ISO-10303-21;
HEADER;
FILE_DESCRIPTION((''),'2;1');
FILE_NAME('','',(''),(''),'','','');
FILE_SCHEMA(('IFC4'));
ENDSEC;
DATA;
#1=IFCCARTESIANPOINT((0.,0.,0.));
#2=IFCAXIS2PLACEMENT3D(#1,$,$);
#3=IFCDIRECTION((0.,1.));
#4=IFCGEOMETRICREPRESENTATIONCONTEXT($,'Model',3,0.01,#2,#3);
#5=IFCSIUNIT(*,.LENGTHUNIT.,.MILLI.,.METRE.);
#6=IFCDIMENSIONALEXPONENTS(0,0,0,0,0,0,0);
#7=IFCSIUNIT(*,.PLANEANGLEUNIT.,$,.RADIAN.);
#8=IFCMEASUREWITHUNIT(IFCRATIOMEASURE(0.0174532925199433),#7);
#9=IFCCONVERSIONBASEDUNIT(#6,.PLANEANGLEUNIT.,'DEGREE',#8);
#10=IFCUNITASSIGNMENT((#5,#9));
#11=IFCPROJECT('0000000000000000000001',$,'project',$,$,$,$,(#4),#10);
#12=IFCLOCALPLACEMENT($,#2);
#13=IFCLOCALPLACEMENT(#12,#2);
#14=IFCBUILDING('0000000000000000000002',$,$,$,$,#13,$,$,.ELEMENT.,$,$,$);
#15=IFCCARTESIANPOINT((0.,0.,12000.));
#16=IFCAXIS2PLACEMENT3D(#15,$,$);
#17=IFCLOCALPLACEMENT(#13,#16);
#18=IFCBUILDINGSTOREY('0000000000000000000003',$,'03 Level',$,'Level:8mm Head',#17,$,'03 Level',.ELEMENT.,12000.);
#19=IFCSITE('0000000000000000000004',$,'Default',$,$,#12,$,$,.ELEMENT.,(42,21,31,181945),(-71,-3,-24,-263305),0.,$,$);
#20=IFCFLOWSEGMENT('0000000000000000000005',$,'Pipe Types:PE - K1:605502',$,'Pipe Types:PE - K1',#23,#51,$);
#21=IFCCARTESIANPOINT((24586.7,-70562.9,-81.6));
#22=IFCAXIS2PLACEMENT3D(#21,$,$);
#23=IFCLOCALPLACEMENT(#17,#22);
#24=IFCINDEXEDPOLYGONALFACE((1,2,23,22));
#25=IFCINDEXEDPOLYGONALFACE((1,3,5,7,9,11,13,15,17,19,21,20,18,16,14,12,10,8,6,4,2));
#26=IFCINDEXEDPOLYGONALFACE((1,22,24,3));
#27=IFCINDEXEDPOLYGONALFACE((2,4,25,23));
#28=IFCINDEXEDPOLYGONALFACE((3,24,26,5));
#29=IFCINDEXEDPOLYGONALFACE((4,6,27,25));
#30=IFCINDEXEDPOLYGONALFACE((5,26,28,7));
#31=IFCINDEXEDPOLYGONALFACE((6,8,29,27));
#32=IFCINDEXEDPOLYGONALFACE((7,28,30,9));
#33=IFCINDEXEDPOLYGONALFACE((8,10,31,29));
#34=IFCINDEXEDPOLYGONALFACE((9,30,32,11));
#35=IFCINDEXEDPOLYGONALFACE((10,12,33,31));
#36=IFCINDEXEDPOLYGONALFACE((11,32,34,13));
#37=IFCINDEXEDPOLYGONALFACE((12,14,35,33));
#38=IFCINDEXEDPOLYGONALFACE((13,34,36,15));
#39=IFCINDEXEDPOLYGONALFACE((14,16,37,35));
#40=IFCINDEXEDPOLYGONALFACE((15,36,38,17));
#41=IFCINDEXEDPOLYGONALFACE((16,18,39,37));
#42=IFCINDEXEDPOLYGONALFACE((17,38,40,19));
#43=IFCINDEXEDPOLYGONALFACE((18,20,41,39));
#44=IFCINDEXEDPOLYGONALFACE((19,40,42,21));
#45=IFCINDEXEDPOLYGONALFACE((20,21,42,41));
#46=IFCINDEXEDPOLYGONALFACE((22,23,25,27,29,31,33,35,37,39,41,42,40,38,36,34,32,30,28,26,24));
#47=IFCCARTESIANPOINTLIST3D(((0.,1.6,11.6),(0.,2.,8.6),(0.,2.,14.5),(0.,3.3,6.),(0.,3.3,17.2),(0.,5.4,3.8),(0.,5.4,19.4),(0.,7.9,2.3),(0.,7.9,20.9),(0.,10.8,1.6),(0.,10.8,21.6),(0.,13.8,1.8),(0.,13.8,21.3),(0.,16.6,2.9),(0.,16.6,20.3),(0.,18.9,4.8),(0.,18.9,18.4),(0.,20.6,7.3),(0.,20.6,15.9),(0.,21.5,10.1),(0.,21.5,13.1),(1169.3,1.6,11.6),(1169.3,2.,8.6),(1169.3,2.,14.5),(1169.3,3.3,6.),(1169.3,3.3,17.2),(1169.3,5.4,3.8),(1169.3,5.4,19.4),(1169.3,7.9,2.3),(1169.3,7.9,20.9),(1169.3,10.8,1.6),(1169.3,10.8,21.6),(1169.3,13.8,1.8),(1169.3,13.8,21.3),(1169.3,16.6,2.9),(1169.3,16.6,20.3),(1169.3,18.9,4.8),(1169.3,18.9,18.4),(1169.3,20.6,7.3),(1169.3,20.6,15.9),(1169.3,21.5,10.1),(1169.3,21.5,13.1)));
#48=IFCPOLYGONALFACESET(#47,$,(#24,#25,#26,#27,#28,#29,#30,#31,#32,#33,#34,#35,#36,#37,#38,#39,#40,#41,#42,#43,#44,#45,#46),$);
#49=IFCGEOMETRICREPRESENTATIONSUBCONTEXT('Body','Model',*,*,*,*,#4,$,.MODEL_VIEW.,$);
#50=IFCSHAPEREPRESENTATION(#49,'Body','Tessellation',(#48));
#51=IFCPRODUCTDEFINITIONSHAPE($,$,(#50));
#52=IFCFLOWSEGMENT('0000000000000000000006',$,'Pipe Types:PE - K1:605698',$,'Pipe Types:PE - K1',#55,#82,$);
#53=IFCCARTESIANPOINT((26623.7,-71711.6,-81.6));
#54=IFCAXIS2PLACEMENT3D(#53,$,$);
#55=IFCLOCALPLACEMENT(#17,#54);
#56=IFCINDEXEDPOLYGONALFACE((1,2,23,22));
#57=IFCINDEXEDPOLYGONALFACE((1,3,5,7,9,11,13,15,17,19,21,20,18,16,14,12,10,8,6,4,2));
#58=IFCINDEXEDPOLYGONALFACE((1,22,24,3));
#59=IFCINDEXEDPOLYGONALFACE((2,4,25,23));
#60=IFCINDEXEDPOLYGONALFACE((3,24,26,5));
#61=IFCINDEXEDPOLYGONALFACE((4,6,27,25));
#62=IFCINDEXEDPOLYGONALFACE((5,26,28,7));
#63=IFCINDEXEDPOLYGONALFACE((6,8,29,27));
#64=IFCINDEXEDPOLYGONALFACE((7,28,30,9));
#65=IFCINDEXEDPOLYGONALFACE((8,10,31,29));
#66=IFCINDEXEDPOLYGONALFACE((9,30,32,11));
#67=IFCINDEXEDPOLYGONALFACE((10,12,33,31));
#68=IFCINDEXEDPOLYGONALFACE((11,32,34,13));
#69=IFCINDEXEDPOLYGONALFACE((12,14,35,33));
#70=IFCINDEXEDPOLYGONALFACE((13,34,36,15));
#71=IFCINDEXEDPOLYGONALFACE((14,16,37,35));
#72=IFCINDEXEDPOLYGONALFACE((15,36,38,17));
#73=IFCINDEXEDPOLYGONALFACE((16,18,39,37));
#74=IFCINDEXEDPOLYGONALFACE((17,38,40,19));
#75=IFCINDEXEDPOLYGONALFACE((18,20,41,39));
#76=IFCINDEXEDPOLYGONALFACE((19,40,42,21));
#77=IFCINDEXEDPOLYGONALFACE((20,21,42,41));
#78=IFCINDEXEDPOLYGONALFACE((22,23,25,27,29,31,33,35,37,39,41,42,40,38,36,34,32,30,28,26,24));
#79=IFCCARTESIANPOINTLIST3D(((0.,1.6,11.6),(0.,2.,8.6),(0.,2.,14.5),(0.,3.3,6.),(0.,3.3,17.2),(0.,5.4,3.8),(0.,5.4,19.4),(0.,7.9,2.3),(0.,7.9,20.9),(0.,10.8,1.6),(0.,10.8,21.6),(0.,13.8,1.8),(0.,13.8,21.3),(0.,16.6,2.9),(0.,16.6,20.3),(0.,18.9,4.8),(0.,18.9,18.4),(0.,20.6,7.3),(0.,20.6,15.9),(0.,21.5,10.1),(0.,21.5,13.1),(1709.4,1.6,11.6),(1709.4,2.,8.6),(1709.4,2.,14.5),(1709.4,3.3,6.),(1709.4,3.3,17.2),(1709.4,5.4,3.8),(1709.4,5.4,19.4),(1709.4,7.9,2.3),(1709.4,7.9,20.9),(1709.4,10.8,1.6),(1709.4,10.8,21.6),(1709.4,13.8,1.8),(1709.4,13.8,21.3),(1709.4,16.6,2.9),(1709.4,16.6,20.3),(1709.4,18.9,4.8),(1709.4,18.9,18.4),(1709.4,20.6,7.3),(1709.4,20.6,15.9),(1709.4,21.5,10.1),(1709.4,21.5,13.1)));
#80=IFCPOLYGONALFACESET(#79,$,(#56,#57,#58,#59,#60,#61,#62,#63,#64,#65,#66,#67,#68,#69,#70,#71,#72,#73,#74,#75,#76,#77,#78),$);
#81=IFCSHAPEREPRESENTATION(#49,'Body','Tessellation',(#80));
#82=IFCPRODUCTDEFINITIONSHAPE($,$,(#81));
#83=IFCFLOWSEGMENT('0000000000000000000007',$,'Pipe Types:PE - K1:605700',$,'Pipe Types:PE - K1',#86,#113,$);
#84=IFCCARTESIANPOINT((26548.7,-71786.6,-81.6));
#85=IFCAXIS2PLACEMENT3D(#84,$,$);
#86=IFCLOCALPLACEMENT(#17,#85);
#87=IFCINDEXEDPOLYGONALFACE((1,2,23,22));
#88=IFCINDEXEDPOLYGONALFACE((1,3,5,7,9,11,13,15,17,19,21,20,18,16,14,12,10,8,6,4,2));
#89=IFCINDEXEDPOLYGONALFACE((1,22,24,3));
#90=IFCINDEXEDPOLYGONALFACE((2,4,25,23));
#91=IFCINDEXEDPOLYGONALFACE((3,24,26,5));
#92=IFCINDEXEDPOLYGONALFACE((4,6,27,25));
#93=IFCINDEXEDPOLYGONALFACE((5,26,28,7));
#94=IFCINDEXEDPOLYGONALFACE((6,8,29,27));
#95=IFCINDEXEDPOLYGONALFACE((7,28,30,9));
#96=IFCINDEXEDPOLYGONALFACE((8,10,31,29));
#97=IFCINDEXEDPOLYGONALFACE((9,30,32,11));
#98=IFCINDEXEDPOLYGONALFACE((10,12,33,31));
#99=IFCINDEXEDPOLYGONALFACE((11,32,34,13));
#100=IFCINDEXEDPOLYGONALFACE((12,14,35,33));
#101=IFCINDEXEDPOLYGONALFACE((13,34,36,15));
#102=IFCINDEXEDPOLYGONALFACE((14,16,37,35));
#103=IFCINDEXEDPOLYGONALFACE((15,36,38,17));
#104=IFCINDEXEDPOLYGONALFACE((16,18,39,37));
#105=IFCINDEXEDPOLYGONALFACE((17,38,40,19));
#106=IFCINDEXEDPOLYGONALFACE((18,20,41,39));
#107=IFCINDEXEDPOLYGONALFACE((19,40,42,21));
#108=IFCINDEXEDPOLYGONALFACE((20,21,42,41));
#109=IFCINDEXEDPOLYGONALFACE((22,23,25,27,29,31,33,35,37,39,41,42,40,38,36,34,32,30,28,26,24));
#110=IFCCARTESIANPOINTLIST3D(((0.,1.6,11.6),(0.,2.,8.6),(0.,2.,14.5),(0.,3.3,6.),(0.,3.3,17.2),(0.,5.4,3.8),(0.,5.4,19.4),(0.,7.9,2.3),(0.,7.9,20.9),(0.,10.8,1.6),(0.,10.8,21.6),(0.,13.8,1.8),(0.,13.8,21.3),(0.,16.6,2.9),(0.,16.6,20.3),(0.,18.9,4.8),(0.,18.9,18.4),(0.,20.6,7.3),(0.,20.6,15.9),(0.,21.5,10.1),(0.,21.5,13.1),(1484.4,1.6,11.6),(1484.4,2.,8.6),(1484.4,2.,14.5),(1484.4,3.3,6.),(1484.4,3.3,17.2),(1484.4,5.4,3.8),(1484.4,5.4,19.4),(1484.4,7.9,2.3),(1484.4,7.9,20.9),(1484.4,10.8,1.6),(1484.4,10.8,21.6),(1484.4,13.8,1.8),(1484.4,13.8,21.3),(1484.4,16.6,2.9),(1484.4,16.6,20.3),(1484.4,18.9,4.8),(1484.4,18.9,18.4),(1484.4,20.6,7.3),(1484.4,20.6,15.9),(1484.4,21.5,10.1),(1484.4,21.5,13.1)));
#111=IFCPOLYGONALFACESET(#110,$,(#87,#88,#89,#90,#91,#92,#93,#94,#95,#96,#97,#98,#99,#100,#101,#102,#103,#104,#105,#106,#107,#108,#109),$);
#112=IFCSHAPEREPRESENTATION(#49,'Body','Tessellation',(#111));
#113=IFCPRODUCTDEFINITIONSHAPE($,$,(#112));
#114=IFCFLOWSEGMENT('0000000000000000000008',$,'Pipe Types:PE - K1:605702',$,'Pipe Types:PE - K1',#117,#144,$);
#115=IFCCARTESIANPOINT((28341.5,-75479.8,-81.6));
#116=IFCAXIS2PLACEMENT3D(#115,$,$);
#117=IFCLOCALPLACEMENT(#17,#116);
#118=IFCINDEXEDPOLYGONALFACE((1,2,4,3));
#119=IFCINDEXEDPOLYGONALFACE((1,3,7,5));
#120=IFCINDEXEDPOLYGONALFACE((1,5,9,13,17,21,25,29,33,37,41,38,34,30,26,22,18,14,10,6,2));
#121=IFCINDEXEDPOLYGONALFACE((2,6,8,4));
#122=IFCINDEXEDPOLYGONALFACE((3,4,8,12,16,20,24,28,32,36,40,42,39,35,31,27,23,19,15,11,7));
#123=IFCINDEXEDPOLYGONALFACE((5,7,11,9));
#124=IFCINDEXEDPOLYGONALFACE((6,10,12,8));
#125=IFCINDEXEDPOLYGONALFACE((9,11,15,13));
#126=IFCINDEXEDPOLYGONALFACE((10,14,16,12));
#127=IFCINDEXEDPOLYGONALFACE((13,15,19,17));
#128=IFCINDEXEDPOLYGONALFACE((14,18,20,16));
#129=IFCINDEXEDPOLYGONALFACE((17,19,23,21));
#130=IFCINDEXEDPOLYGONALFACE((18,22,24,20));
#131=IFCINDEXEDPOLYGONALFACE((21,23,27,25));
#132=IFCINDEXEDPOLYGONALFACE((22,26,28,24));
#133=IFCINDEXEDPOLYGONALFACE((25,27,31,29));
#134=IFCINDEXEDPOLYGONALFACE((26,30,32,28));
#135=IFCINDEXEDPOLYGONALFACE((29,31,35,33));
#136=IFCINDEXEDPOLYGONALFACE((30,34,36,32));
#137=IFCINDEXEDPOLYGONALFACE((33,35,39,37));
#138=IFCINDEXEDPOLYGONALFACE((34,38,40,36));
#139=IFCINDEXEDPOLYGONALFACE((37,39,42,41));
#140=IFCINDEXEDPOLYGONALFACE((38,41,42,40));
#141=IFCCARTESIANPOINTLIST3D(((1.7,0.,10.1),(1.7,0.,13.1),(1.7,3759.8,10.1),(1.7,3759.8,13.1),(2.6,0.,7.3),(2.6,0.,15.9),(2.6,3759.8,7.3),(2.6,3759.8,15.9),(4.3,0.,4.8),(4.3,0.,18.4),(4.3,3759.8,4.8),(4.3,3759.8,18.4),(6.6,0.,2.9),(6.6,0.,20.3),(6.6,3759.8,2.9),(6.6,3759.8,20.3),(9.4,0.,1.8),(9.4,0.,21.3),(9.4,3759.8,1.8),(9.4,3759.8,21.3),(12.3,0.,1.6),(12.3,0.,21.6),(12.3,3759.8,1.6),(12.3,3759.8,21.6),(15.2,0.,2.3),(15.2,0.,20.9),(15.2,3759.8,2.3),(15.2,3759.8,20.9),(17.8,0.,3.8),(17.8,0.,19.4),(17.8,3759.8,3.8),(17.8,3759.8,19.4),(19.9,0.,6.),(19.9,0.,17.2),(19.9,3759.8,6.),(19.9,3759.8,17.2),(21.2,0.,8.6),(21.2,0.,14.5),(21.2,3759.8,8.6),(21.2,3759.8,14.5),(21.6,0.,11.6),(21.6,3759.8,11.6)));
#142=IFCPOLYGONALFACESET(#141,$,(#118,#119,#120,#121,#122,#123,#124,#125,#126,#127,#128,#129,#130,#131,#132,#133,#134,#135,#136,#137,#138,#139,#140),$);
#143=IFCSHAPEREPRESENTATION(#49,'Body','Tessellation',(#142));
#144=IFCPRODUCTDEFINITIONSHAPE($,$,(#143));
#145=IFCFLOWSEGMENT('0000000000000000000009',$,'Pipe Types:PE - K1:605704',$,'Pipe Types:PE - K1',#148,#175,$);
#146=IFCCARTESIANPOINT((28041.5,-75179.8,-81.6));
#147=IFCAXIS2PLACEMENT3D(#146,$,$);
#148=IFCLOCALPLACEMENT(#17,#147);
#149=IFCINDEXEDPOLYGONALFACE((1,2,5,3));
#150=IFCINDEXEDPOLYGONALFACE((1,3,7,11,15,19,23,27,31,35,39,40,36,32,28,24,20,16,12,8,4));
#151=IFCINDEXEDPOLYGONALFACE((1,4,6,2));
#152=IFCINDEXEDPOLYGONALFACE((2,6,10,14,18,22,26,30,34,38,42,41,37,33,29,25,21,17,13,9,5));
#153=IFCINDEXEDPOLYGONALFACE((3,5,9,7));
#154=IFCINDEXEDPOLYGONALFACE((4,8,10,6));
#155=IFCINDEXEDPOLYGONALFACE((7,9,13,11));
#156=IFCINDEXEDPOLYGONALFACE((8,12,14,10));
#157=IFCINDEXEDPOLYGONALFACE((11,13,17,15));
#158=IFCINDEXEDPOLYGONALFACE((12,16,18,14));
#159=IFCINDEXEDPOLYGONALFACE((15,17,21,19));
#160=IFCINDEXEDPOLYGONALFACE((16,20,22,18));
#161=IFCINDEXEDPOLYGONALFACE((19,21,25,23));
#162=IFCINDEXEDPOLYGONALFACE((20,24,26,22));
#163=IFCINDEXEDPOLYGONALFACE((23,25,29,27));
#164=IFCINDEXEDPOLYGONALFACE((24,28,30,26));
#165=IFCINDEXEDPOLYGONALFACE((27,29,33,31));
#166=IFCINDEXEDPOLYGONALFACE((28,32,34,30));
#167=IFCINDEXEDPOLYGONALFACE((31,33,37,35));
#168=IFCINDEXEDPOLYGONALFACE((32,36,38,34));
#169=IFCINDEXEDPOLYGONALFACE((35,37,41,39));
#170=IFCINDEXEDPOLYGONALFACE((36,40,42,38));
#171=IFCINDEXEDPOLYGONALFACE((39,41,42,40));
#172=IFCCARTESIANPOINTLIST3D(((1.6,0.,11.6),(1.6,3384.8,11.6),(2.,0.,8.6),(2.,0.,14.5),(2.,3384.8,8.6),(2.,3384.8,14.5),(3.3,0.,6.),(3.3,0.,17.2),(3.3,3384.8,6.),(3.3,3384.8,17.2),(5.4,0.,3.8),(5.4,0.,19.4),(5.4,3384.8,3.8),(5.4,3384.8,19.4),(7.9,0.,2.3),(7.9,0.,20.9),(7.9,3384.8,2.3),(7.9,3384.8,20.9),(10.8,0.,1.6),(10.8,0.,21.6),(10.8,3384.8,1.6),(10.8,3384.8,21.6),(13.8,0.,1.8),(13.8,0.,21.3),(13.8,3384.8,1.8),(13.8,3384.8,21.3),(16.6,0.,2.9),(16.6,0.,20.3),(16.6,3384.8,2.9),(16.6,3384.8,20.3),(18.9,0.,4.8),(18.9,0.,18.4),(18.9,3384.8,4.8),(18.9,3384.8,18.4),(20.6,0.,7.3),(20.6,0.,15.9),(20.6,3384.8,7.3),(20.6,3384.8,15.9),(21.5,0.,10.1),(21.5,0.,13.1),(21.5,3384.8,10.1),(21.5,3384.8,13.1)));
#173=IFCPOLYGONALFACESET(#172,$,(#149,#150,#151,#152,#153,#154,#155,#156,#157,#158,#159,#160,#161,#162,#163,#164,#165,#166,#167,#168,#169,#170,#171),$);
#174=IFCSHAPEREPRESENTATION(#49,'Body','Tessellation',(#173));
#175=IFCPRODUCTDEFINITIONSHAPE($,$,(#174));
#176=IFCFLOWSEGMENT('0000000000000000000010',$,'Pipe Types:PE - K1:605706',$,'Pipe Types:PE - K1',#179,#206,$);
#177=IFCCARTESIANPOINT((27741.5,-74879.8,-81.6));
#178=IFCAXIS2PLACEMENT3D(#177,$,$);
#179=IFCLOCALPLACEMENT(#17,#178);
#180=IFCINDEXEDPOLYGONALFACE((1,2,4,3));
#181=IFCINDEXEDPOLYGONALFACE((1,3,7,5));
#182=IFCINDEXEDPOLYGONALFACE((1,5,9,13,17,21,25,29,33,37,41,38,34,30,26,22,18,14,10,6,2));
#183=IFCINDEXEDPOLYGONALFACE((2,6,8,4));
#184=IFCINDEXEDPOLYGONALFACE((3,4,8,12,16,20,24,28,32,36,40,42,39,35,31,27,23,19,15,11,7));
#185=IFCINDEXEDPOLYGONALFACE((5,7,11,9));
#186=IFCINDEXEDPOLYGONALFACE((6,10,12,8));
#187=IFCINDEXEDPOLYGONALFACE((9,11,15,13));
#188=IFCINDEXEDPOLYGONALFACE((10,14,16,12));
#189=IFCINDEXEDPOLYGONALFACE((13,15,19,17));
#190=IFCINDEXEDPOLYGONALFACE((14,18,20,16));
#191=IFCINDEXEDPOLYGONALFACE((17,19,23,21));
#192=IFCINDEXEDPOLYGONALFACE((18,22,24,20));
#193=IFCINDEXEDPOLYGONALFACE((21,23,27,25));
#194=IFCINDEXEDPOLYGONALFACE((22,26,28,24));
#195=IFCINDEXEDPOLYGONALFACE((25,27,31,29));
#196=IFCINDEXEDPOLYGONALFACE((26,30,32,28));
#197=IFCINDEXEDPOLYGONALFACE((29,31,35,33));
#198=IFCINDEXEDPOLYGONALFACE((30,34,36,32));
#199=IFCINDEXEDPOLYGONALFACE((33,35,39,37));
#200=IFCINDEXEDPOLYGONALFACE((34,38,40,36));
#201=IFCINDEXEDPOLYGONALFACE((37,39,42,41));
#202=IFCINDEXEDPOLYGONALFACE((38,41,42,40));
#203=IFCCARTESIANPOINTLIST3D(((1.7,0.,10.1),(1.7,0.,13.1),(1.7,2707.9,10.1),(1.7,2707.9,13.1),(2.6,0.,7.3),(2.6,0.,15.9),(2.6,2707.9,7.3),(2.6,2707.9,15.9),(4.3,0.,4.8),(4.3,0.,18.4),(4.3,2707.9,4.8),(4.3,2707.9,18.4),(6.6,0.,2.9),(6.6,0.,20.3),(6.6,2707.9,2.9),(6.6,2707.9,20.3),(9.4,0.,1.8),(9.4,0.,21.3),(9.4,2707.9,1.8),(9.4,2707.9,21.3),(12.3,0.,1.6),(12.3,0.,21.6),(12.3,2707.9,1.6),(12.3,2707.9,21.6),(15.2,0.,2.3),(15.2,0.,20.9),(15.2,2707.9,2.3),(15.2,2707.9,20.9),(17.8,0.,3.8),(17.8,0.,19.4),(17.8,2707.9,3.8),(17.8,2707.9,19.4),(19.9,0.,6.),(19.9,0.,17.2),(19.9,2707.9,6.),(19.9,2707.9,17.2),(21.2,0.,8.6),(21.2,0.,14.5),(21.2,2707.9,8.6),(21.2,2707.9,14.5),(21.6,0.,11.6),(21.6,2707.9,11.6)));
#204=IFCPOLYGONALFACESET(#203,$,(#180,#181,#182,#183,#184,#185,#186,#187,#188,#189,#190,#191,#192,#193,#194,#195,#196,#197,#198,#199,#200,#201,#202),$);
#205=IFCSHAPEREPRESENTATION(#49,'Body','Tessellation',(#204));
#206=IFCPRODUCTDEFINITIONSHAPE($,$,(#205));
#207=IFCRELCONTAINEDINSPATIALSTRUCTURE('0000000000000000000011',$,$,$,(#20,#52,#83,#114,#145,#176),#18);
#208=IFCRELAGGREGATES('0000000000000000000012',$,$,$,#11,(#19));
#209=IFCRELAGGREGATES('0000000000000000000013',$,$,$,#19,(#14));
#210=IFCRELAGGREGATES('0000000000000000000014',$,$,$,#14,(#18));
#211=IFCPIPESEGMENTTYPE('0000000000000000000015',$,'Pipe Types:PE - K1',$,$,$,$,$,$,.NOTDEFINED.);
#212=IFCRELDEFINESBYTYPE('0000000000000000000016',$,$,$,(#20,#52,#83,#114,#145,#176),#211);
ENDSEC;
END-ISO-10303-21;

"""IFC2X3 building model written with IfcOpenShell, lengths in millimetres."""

from ifc_helpers import new_model, entity, si_unit, converted_unit, direction, frame, frame_2d, origin, origin_2d_with_axis, place, context, subcontext, project, spatial, circle, extrude, type_object, element, save


model = new_model("IFC2X3")

# Units and contexts
model_context = context("Model", 3, precision=0.01, world=origin(), true_north=direction((0.0, 1.0)))
body_context = subcontext(model_context, "Body", "Model", "MODEL_VIEW")
ifc_project = project(units=[si_unit("LENGTHUNIT", "METRE", prefix="MILLI"), converted_unit("PLANEANGLEUNIT", "DEGREE", entity("IfcRatioMeasure", 0.0174532925199433), si_unit("PLANEANGLEUNIT", "RADIAN"), dimensions=[0, 0, 0, 0, 0, 0, 0])], contexts=[model_context])

# Site, building, storey
site_placement = place(None, origin())
site = spatial("IfcSite", under=ifc_project, at=site_placement, Name="Default", CompositionType="ELEMENT", RefLatitude=(42, 21, 31, 181945), RefLongitude=(-71, -3, -24, -263305), RefElevation=0.0)
building_placement = place(site_placement, origin())
building = spatial("IfcBuilding", under=site, at=building_placement, CompositionType="ELEMENT")
storey_placement = place(building_placement, frame((0.0, 0.0, 12000.0)))
storey = spatial("IfcBuildingStorey", under=building, at=storey_placement, Name="03 Level", ObjectType="Level:8mm Head", LongName="03 Level", CompositionType="ELEMENT", Elevation=12000.0)

# Flow segments
pipe_segment_type = type_object("IfcPipeSegmentType", Name="Pipe Types:PE - K1", PredefinedType="NOTDEFINED")
flow_segment_1_placement = place(storey_placement, frame((24586.7, -70562.9, -81.6)))
element("IfcFlowSegment", 1, at=flow_segment_1_placement, inside=storey, type_object=pipe_segment_type, Name="Pipe Types:PE - K1:605502", ObjectType="Pipe Types:PE - K1", context=body_context, shape_type="SweptSolid", body=[
    extrude(circle(Radius=10.0, at=origin_2d_with_axis()), frame((0.0, 11.6, 11.6), z_axis=(1.0, 0.0, 0.0), x_axis=(0.0, -1.0, 0.0)), (0.0, 0.0, 1.0), 1169.3),
])
flow_segment_2_placement = place(storey_placement, frame((26623.7, -71711.6, -81.6)))
element("IfcFlowSegment", 2, at=flow_segment_2_placement, inside=storey, type_object=pipe_segment_type, Name="Pipe Types:PE - K1:605698", ObjectType="Pipe Types:PE - K1", context=body_context, shape_type="SweptSolid", body=[
    extrude(circle(Radius=10.0, at=origin_2d_with_axis()), frame((0.0, 11.6, 11.6), z_axis=(1.0, 0.0, 0.0), x_axis=(0.0, -1.0, 0.0)), (0.0, 0.0, 1.0), 1709.4),
])
flow_segment_3_placement = place(storey_placement, frame((26548.7, -71786.6, -81.6)))
element("IfcFlowSegment", 3, at=flow_segment_3_placement, inside=storey, type_object=pipe_segment_type, Name="Pipe Types:PE - K1:605700", ObjectType="Pipe Types:PE - K1", context=body_context, shape_type="SweptSolid", body=[
    extrude(circle(Radius=10.0, at=origin_2d_with_axis()), frame((0.0, 11.6, 11.6), z_axis=(1.0, 0.0, 0.0), x_axis=(0.0, -1.0, 0.0)), (0.0, 0.0, 1.0), 1484.4),
])
flow_segment_4_placement = place(storey_placement, frame((28341.5, -75479.8, -81.6)))
element("IfcFlowSegment", 4, at=flow_segment_4_placement, inside=storey, type_object=pipe_segment_type, Name="Pipe Types:PE - K1:605702", ObjectType="Pipe Types:PE - K1", context=body_context, shape_type="SweptSolid", body=[
    extrude(circle(Radius=10.0, at=origin_2d_with_axis()), frame((11.6, 0.0, 11.6), z_axis=(0.0, 1.0, 0.0), x_axis=(1.0, 0.0, 0.0)), (0.0, 0.0, 1.0), 3759.8),
])
flow_segment_5_placement = place(storey_placement, frame((28041.5, -75179.8, -81.6)))
element("IfcFlowSegment", 5, at=flow_segment_5_placement, inside=storey, type_object=pipe_segment_type, Name="Pipe Types:PE - K1:605704", ObjectType="Pipe Types:PE - K1", context=body_context, shape_type="SweptSolid", body=[
    extrude(circle(Radius=10.0, at=frame_2d((0.0, 0.0), x_axis=(1.0, 0.0))), frame((11.6, 0.0, 11.6), z_axis=(0.0, 1.0, 0.0), x_axis=(-1.0, 0.0, 0.0)), (0.0, 0.0, 1.0), 3384.8),
])
flow_segment_6_placement = place(storey_placement, frame((27741.5, -74879.8, -81.6)))
element("IfcFlowSegment", 6, at=flow_segment_6_placement, inside=storey, type_object=pipe_segment_type, Name="Pipe Types:PE - K1:605706", ObjectType="Pipe Types:PE - K1", context=body_context, shape_type="SweptSolid", body=[
    extrude(circle(Radius=10.0, at=origin_2d_with_axis()), frame((11.6, 0.0, 11.6), z_axis=(0.0, 1.0, 0.0), x_axis=(1.0, 0.0, 0.0)), (0.0, 0.0, 1.0), 2707.9),
])

save(model, "model.ifc")
